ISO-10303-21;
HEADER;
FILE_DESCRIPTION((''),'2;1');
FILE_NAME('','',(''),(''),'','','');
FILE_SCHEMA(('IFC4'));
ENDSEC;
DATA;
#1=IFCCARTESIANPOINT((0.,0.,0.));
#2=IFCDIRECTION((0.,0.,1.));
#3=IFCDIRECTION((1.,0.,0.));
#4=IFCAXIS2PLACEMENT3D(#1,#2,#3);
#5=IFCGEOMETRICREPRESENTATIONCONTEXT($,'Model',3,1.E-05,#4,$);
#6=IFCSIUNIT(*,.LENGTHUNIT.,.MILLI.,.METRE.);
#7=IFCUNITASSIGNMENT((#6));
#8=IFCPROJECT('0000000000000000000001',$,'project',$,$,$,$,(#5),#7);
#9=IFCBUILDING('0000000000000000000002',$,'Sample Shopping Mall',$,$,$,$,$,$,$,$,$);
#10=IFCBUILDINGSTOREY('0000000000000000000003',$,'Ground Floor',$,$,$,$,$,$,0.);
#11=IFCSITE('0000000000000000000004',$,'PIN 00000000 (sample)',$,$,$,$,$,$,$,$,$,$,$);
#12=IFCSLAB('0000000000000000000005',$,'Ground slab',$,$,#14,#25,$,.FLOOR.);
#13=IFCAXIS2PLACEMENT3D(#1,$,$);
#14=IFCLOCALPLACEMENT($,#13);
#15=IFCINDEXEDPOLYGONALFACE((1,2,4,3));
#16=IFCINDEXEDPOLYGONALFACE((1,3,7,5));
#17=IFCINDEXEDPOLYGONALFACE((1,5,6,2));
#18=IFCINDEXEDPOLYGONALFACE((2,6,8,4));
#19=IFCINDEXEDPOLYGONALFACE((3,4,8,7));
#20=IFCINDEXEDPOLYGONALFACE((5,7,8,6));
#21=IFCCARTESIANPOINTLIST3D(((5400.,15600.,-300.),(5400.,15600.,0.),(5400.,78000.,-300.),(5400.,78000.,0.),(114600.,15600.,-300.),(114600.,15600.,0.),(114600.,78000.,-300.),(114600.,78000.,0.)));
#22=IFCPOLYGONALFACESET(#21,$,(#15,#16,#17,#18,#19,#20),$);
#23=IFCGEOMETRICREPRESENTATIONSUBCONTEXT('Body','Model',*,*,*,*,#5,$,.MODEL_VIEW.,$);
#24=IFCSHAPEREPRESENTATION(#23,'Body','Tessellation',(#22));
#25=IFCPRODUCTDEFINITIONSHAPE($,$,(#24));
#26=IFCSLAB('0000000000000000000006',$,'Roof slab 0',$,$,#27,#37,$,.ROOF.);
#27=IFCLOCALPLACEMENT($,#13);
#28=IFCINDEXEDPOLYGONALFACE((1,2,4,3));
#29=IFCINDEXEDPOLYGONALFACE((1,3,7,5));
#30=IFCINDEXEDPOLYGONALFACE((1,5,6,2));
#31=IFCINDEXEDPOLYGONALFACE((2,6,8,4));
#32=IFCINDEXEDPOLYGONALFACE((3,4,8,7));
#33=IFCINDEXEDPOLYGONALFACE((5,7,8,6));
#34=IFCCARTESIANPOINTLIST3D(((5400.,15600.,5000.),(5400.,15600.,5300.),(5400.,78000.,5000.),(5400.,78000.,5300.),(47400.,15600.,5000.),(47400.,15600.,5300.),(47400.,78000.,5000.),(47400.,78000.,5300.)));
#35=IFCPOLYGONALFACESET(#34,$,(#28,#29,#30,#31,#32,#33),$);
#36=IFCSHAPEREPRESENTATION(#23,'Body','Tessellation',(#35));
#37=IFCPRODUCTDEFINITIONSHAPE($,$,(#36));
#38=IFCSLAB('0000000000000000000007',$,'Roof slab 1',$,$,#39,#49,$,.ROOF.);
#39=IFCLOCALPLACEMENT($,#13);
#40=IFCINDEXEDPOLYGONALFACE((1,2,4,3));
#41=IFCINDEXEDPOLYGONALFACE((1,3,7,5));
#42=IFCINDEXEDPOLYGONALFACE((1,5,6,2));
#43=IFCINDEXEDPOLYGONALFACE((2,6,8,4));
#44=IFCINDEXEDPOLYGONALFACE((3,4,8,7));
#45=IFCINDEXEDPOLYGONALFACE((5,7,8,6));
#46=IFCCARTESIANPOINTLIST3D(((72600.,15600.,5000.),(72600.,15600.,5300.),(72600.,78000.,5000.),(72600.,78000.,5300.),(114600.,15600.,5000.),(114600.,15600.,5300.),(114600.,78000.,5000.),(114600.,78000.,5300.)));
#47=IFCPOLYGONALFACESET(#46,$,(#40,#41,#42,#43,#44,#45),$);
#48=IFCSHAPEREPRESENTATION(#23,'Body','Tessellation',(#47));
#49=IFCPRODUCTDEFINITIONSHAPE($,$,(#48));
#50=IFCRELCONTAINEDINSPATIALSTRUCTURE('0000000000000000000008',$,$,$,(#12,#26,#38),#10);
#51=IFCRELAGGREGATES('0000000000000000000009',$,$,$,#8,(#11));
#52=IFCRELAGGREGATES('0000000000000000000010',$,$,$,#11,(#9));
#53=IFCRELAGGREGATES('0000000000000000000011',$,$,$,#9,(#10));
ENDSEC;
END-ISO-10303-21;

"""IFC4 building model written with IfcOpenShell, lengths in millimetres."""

from ifc_helpers import new_model, si_unit, frame, origin_with_axes, place, context, subcontext, project, spatial, indexed_curve, outline, extrude, element, save


model = new_model("IFC4")

# Units and contexts
model_context = context("Model", 3, precision=1e-05, world=origin_with_axes())
body_context = subcontext(model_context, "Body", "Model", "MODEL_VIEW")
ifc_project = project(units=[si_unit("LENGTHUNIT", "METRE", prefix="MILLI")], contexts=[model_context])

# Site, building, storey
site = spatial("IfcSite", under=ifc_project, Name="PIN 00000000 (sample)")
building = spatial("IfcBuilding", under=site, Name="Sample Shopping Mall")
storey = spatial("IfcBuildingStorey", under=building, Name="Ground Floor", Elevation=0.0)

# Slabs
slab_1_placement = place(None, frame((0.0, 0.0, -300.0), z_axis=(0.0, 0.0, 1.0), x_axis=(1.0, 0.0, 0.0)))
element("IfcSlab", 1, at=slab_1_placement, inside=storey, Name="Ground slab", PredefinedType="FLOOR", context=body_context, shape_type="SweptSolid", body=[
    extrude(outline(indexed_curve([(5400.0, 15600.0), (114600.0, 15600.0), (114600.0, 78000.0), (5400.0, 78000.0)])), None, (0.0, 0.0, 1.0), 300.0),
])
slab_2_placement = place(None, frame((0.0, 0.0, 5000.0), z_axis=(0.0, 0.0, 1.0), x_axis=(1.0, 0.0, 0.0)))
element("IfcSlab", 2, at=slab_2_placement, inside=storey, Name="Roof slab 0", PredefinedType="ROOF", context=body_context, shape_type="SweptSolid", body=[
    extrude(outline(indexed_curve([(5400.0, 15600.0), (47400.0, 15600.0), (47400.0, 78000.0), (5400.0, 78000.0)])), None, (0.0, 0.0, 1.0), 300.0),
])
slab_3_placement = place(None, frame((0.0, 0.0, 5000.0), z_axis=(0.0, 0.0, 1.0), x_axis=(1.0, 0.0, 0.0)))
element("IfcSlab", 3, at=slab_3_placement, inside=storey, Name="Roof slab 1", PredefinedType="ROOF", context=body_context, shape_type="SweptSolid", body=[
    extrude(outline(indexed_curve([(72600.0, 15600.0), (114600.0, 15600.0), (114600.0, 78000.0), (72600.0, 78000.0)])), None, (0.0, 0.0, 1.0), 300.0),
])

save(model, "model.ifc")
